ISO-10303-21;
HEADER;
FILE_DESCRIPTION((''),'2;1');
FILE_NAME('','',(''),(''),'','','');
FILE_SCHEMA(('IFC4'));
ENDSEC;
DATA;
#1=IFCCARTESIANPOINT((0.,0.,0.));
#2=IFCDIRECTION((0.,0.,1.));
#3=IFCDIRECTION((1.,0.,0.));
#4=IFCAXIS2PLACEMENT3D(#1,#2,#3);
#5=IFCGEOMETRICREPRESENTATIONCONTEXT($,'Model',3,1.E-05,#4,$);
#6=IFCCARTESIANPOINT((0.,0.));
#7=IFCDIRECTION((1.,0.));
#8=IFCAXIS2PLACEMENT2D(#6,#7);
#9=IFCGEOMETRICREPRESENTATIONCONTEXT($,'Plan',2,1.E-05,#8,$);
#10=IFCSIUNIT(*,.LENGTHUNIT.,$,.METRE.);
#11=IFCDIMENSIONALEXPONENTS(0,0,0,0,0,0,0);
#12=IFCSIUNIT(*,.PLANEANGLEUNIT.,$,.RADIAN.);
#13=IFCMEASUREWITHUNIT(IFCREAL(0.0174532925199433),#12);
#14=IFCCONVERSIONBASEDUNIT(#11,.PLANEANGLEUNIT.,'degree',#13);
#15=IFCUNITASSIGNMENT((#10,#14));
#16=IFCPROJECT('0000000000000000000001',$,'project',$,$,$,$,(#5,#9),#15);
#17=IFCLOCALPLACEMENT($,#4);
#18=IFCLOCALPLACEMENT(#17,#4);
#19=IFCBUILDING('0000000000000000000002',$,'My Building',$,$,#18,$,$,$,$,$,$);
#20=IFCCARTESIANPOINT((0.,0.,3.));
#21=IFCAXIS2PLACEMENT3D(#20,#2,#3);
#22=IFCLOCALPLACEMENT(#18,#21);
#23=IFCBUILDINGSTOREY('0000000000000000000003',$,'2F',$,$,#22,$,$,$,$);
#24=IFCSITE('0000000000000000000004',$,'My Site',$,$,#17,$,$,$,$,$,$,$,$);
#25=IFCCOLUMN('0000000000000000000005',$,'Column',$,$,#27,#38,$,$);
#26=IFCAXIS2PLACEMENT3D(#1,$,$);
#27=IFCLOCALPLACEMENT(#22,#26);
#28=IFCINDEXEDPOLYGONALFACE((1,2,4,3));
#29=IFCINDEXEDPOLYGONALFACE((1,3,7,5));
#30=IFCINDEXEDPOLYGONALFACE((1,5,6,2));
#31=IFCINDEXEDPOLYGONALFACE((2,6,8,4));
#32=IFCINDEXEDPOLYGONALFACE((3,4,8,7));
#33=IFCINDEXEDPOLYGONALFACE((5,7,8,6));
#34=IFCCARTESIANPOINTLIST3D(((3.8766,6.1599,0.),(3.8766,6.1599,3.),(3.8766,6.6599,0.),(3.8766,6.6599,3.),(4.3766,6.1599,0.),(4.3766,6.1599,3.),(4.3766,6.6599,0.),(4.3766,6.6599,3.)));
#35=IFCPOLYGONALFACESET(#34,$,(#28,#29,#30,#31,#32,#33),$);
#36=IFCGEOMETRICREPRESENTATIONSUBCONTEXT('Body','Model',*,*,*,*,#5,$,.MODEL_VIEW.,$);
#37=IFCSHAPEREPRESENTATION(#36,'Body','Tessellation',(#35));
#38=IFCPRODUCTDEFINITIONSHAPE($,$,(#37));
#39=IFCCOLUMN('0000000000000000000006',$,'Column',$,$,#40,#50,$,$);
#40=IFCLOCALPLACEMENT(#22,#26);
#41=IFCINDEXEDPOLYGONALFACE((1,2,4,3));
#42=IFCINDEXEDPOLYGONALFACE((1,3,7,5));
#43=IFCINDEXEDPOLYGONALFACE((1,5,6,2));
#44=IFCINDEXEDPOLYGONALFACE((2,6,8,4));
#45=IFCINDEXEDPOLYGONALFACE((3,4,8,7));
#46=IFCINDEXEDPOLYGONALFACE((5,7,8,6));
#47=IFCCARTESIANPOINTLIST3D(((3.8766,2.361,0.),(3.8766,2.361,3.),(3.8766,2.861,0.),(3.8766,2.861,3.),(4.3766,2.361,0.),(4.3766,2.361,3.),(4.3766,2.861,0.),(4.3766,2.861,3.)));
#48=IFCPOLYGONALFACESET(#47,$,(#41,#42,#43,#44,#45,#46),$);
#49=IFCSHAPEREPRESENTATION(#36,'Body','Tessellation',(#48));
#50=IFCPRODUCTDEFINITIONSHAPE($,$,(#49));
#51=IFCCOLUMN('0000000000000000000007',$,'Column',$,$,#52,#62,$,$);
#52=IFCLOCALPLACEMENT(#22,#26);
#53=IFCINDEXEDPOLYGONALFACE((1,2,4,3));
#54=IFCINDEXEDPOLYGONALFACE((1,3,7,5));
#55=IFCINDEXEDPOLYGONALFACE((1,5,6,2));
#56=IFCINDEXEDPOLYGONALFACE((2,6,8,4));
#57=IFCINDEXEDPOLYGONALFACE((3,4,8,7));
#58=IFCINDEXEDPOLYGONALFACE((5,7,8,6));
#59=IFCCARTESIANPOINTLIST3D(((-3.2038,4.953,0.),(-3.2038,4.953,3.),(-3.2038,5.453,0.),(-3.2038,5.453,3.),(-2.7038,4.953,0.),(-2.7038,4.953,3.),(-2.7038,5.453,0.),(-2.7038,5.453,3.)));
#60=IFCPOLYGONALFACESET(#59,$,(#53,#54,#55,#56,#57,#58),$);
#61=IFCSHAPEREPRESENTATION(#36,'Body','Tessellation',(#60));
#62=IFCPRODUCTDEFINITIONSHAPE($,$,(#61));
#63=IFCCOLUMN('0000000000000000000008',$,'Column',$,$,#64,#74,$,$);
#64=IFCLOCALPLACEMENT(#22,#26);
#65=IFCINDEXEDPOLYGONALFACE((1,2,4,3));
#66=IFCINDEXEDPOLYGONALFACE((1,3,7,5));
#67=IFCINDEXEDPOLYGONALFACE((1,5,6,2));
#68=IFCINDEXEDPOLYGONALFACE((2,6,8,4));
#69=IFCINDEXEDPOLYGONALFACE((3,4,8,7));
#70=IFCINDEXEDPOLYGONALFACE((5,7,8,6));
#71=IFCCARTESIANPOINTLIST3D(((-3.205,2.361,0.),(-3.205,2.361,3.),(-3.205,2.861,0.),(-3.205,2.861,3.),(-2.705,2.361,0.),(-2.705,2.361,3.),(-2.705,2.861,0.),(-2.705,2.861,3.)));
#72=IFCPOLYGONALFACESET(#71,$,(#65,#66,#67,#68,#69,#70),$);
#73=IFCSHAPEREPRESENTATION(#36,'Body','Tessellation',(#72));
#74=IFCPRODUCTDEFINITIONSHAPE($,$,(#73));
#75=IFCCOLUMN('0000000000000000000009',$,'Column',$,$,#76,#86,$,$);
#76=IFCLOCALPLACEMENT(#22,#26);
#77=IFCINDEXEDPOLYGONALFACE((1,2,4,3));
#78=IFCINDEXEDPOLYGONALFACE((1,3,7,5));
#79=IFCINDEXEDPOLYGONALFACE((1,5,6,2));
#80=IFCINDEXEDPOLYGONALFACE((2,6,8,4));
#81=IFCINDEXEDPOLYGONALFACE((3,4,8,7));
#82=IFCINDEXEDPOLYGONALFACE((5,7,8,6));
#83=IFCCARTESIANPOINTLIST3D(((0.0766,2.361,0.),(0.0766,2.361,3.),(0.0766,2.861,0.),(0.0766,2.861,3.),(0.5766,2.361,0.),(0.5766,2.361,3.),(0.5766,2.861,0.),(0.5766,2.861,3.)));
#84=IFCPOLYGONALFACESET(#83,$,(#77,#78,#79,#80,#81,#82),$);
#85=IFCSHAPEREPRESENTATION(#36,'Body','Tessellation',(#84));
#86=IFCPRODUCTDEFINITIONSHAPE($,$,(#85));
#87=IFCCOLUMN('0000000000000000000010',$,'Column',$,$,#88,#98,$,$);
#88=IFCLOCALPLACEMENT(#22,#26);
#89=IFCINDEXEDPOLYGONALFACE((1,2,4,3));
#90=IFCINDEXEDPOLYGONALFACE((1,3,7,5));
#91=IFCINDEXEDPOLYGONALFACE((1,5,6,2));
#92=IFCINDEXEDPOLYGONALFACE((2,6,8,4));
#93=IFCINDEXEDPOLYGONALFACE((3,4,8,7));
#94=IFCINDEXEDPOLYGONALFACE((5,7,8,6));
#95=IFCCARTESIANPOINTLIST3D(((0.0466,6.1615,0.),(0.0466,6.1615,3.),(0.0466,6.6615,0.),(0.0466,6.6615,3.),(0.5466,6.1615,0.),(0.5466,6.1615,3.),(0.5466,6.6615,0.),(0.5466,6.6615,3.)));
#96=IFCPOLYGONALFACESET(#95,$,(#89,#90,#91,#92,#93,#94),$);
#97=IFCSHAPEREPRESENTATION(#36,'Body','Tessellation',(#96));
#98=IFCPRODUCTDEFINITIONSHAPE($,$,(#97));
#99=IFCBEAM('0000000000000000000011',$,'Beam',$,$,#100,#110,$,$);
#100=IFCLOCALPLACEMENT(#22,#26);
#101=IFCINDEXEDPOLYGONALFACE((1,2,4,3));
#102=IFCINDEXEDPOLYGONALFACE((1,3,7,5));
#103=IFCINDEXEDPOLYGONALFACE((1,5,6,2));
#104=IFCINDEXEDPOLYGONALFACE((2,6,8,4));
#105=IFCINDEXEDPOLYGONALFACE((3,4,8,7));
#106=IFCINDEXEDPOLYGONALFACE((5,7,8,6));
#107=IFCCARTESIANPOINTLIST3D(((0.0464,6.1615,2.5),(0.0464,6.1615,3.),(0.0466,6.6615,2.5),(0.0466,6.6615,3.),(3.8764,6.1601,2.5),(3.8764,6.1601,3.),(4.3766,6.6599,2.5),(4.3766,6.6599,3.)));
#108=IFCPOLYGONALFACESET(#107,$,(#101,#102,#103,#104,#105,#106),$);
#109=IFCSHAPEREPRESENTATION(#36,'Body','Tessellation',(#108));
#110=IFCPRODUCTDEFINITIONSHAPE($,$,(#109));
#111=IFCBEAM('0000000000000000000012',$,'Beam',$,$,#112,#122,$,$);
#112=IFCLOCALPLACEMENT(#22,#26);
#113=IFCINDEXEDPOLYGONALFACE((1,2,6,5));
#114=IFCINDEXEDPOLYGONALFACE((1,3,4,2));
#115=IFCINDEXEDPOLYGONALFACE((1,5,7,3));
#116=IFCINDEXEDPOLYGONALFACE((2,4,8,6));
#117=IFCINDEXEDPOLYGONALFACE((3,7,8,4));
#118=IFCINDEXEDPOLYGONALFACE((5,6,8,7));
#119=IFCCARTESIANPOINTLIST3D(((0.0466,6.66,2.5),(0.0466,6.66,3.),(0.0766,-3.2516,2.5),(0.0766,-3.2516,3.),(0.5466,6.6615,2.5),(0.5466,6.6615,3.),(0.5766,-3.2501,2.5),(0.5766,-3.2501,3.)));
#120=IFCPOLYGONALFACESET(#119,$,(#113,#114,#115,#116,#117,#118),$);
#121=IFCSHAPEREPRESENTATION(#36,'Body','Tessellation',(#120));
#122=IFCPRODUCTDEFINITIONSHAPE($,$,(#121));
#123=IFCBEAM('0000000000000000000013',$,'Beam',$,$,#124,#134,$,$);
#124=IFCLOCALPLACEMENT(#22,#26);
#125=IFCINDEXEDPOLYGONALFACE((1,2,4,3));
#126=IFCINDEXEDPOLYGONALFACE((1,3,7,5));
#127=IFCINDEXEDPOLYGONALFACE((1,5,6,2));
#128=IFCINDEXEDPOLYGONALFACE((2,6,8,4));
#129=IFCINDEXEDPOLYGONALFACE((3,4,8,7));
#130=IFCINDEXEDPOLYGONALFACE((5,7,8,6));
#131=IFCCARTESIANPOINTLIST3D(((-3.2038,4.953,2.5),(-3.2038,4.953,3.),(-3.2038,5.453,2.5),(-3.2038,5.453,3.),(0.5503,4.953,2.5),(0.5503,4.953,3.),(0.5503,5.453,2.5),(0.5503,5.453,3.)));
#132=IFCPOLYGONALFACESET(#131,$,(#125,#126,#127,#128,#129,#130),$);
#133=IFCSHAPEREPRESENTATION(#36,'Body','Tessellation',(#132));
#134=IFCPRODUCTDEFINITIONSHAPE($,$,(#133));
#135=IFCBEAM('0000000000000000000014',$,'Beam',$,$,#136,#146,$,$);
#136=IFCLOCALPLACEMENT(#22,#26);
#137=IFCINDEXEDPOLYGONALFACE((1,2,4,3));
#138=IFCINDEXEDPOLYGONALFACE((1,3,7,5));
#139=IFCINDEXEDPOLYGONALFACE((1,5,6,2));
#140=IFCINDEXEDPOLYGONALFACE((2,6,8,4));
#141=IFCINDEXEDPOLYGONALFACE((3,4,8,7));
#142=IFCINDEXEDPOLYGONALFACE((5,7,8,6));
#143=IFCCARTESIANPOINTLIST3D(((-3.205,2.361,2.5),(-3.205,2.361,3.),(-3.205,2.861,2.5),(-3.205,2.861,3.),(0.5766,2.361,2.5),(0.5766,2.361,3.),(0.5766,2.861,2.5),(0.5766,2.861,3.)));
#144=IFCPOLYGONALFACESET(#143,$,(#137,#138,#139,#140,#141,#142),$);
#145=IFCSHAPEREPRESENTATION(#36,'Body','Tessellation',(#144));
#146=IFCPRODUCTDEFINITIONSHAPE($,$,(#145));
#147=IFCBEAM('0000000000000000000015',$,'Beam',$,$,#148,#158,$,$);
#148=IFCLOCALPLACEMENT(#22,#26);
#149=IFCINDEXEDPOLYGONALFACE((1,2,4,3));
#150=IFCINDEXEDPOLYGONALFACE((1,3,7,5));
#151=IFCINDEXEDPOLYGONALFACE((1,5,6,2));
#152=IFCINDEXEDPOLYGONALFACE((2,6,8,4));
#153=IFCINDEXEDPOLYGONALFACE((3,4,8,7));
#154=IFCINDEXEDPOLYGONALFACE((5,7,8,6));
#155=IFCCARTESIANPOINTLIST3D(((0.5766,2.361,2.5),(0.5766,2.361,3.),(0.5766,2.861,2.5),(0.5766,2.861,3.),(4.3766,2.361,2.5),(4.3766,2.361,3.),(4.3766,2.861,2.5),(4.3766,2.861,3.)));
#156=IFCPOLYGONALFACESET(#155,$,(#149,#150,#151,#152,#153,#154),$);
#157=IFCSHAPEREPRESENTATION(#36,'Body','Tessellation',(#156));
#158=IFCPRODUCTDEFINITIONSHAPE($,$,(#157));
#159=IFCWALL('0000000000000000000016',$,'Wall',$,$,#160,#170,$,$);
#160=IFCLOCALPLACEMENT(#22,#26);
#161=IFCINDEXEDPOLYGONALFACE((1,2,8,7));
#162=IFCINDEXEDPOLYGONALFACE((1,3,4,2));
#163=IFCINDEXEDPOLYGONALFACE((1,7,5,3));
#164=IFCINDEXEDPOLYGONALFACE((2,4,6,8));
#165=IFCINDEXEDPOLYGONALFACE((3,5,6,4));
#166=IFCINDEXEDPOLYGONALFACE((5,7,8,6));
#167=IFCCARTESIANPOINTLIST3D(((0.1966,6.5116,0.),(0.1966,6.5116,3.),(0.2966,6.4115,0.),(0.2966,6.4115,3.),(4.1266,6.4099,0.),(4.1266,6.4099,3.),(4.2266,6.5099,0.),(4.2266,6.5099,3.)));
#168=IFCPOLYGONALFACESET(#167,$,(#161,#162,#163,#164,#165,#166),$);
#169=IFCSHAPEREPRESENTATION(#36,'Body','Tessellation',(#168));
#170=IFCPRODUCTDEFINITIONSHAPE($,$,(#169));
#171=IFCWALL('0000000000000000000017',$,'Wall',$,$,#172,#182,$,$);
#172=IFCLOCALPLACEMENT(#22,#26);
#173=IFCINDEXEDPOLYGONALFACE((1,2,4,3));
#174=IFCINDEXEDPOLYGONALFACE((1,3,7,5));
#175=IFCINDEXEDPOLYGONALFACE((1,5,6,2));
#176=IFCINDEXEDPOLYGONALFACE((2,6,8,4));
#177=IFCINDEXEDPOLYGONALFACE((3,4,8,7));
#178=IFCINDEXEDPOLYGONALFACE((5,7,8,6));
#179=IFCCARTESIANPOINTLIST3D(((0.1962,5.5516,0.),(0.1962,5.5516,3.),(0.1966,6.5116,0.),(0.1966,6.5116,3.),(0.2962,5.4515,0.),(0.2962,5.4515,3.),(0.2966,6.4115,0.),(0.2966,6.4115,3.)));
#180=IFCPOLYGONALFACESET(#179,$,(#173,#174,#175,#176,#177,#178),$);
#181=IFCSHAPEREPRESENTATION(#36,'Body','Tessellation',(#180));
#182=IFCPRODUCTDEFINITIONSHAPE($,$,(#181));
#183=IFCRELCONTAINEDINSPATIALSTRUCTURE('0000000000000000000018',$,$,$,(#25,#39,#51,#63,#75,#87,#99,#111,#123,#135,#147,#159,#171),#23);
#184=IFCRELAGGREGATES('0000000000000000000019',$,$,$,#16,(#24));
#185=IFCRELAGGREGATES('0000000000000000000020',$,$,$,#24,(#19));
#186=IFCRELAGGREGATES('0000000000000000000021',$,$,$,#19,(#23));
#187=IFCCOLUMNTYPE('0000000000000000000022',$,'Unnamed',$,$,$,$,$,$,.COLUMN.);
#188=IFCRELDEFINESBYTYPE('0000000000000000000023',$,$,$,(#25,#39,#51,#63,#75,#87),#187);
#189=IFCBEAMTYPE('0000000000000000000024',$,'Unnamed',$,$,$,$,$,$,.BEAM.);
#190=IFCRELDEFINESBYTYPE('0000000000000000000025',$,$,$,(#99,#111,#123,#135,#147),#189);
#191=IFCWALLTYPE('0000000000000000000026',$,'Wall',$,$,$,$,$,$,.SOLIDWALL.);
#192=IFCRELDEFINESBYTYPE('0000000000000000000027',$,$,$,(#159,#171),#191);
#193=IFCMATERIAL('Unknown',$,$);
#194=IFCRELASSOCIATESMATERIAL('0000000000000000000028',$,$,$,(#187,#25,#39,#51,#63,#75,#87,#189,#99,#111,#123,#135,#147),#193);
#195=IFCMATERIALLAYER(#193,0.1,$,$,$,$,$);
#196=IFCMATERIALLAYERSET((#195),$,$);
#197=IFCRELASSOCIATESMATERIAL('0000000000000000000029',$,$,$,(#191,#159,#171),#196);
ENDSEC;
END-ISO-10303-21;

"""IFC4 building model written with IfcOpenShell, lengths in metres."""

from ifc_helpers import new_model, entity, si_unit, converted_unit, frame, origin_with_axes, origin_2d_with_axis, place, context, subcontext, project, spatial, line, indexed_curve, rectangle, outline, extrude, clip, halfspace, material, layer, layer_set, layer_usage, material_profile, profile_set, profile_usage, type_object, element, save


model = new_model("IFC4")

# Units and contexts
model_context = context("Model", 3, precision=1e-05, world=origin_with_axes())
plan_context = context("Plan", 2, precision=1e-05, world=origin_2d_with_axis())
body_context_1 = subcontext(model_context, "Body", "Model", "MODEL_VIEW")
ifc_project = project(units=[si_unit("LENGTHUNIT", "METRE"), converted_unit("PLANEANGLEUNIT", "degree", entity("IfcReal", 0.0174532925199433), si_unit("PLANEANGLEUNIT", "RADIAN"), dimensions=[0, 0, 0, 0, 0, 0, 0])], contexts=[model_context, plan_context])

# Site, building, storey
site_placement = place(None, origin_with_axes())
site = spatial("IfcSite", under=ifc_project, at=site_placement, Name="My Site")
building_placement = place(site_placement, origin_with_axes())
building = spatial("IfcBuilding", under=site, at=building_placement, Name="My Building")
storey_placement = place(building_placement, frame((0.0, 0.0, 3.0), z_axis=(0.0, 0.0, 1.0), x_axis=(1.0, 0.0, 0.0)))
storey = spatial("IfcBuildingStorey", under=building, at=storey_placement, Name="2F")

# Columns
ifc_material = material(Name="Unknown")
ifc_material_profile_1 = material_profile(ifc_material, rectangle(XDim=0.5, YDim=0.5))
ifc_profile_set_1 = profile_set([ifc_material_profile_1])
ifc_profile_usage_1 = profile_usage(ifc_profile_set_1, cardinal=9)
column_type = type_object("IfcColumnType", Name="Unnamed", PredefinedType="COLUMN", material=ifc_profile_set_1)
column_1_placement = place(storey_placement, frame((3.8766, 6.6599, 0.0), z_axis=(0.0, 0.0, 1.0), x_axis=(1.0, 0.0, 0.0)))
element("IfcColumn", 1, at=column_1_placement, inside=storey, type_object=column_type, material=ifc_profile_usage_1, Name="Column", context=body_context_1, shape_type="SweptSolid", body=[
    extrude(rectangle(XDim=0.5, YDim=0.5), frame((0.25, -0.25, 0.0), z_axis=(0.0, 0.0, 1.0), x_axis=(1.0, 0.0, 0.0)), (0.0, 0.0, 1.0), 3.0),
])
ifc_profile_usage_2 = profile_usage(ifc_profile_set_1, cardinal=7)
column_2_placement = place(storey_placement, frame((4.3766, 2.861, 0.0), z_axis=(0.0, 0.0, 1.0), x_axis=(1.0, 0.0, 0.0)))
element("IfcColumn", 2, at=column_2_placement, inside=storey, type_object=column_type, material=ifc_profile_usage_2, Name="Column", context=body_context_1, shape_type="SweptSolid", body=[
    extrude(rectangle(XDim=0.5, YDim=0.5), frame((-0.25, -0.25, 0.0), z_axis=(0.0, 0.0, 1.0), x_axis=(1.0, 0.0, 0.0)), (0.0, 0.0, 1.0), 3.0),
])
ifc_profile_usage_3 = profile_usage(ifc_profile_set_1, cardinal=9)
column_3_placement = place(storey_placement, frame((-3.2038, 5.453, 0.0), z_axis=(0.0, 0.0, 1.0), x_axis=(1.0, 0.0, 0.0)))
element("IfcColumn", 3, at=column_3_placement, inside=storey, type_object=column_type, material=ifc_profile_usage_3, Name="Column", context=body_context_1, shape_type="SweptSolid", body=[
    extrude(rectangle(XDim=0.5, YDim=0.5), frame((0.25, -0.25, 0.0), z_axis=(0.0, 0.0, 1.0), x_axis=(1.0, 0.0, 0.0)), (0.0, 0.0, 1.0), 3.0),
])
ifc_profile_usage_4 = profile_usage(ifc_profile_set_1, cardinal=7)
column_4_placement = place(storey_placement, frame((-2.705, 2.861, 0.0), z_axis=(0.0, 0.0, 1.0), x_axis=(1.0, 0.0, 0.0)))
element("IfcColumn", 4, at=column_4_placement, inside=storey, type_object=column_type, material=ifc_profile_usage_4, Name="Column", context=body_context_1, shape_type="SweptSolid", body=[
    extrude(rectangle(XDim=0.5, YDim=0.5), frame((-0.25, -0.25, 0.0), z_axis=(0.0, 0.0, 1.0), x_axis=(1.0, 0.0, 0.0)), (0.0, 0.0, 1.0), 3.0),
])
ifc_profile_usage_5 = profile_usage(ifc_profile_set_1, cardinal=7)
column_5_placement = place(storey_placement, frame((0.5766, 2.861, 0.0), z_axis=(0.0, 0.0, 1.0), x_axis=(1.0, 0.0, 0.0)))
element("IfcColumn", 5, at=column_5_placement, inside=storey, type_object=column_type, material=ifc_profile_usage_5, Name="Column", context=body_context_1, shape_type="SweptSolid", body=[
    extrude(rectangle(XDim=0.5, YDim=0.5), frame((-0.25, -0.25, 0.0), z_axis=(0.0, 0.0, 1.0), x_axis=(1.0, 0.0, 0.0)), (0.0, 0.0, 1.0), 3.0),
])
ifc_profile_usage_6 = profile_usage(ifc_profile_set_1, cardinal=7)
column_6_placement = place(storey_placement, frame((0.5466, 6.6615, 0.0), z_axis=(0.0, 0.0, 1.0), x_axis=(1.0, 0.0, 0.0)))
element("IfcColumn", 6, at=column_6_placement, inside=storey, type_object=column_type, material=ifc_profile_usage_6, Name="Column", context=body_context_1, shape_type="SweptSolid", body=[
    extrude(rectangle(XDim=0.5, YDim=0.5), frame((-0.25, -0.25, 0.0), z_axis=(0.0, 0.0, 1.0), x_axis=(1.0, 0.0, 0.0)), (0.0, 0.0, 1.0), 3.0),
])

# Beams
ifc_material_profile_2 = material_profile(ifc_material, rectangle(XDim=0.5, YDim=0.5))
ifc_profile_set_2 = profile_set([ifc_material_profile_2])
ifc_profile_usage_7 = profile_usage(ifc_profile_set_2, cardinal=7)
beam_type = type_object("IfcBeamType", Name="Unnamed", PredefinedType="BEAM", material=ifc_profile_set_2)
beam_1_placement = place(storey_placement, frame((0.0466, 6.6615, 3.0), z_axis=(1.0, -0.000377, 0.0), x_axis=(0.000377, 1.0, 0.0)))
element("IfcBeam", 7, at=beam_1_placement, inside=storey, type_object=beam_type, material=ifc_profile_usage_7, Name="Beam", context=body_context_1, shape_type="Clipping", body=[
    clip(extrude(rectangle(XDim=0.5, YDim=0.5), frame((-0.25, -0.25, 0.0), z_axis=(0.0, 0.0, 1.0), x_axis=(1.0, 0.0, 0.0)), (0.0, 0.0, 1.0), 4.83), halfspace(frame((0.0, -6.0, 4.33), z_axis=(-0.707114, 0.0, 0.707099), x_axis=(0.0, 1.0, 0.0)), False)),
])
ifc_profile_usage_8 = profile_usage(ifc_profile_set_2, cardinal=7)
beam_2_placement = place(storey_placement, frame((0.5466, 6.6615, 3.0), z_axis=(0.003031, -0.999995, 0.0), x_axis=(0.999995, 0.003031, 0.0)))
element("IfcBeam", 8, at=beam_2_placement, inside=storey, type_object=beam_type, material=ifc_profile_usage_8, Name="Beam", context=body_context_1, shape_type="SweptSolid", body=[
    extrude(rectangle(XDim=0.5, YDim=0.5), frame((-0.25, -0.25, 0.0), z_axis=(0.0, 0.0, 1.0), x_axis=(1.0, 0.0, 0.0)), (0.0, 0.0, 1.0), 9.9117),
])
ifc_profile_usage_9 = profile_usage(ifc_profile_set_2, cardinal=7)
beam_3_placement = place(storey_placement, frame((-3.2038, 5.453, 3.0), z_axis=(1.0, 0.0, 0.000001), x_axis=(0.0, 1.0, 0.0)))
element("IfcBeam", 9, at=beam_3_placement, inside=storey, type_object=beam_type, material=ifc_profile_usage_9, Name="Beam", context=body_context_1, shape_type="SweptSolid", body=[
    extrude(rectangle(XDim=0.5, YDim=0.5), frame((-0.25, -0.25, 0.0), z_axis=(0.0, 0.0, 1.0), x_axis=(1.0, 0.0, 0.0)), (0.0, 0.0, 1.0), 3.7541),
])
ifc_profile_usage_10 = profile_usage(ifc_profile_set_2, cardinal=7)
beam_4_placement = place(storey_placement, frame((-3.205, 2.861, 3.0), z_axis=(1.0, 0.0, 0.0), x_axis=(0.0, 1.0, 0.0)))
element("IfcBeam", 10, at=beam_4_placement, inside=storey, type_object=beam_type, material=ifc_profile_usage_10, Name="Beam", context=body_context_1, shape_type="SweptSolid", body=[
    extrude(rectangle(XDim=0.5, YDim=0.5), frame((-0.25, -0.25, 0.0), z_axis=(0.0, 0.0, 1.0), x_axis=(1.0, 0.0, 0.0)), (0.0, 0.0, 1.0), 3.7816),
])
ifc_profile_usage_11 = profile_usage(ifc_profile_set_2, cardinal=7)
beam_5_placement = place(storey_placement, frame((0.5766, 2.861, 3.0), z_axis=(1.0, 0.000001, 0.0), x_axis=(-0.000001, 1.0, 0.0)))
element("IfcBeam", 11, at=beam_5_placement, inside=storey, type_object=beam_type, material=ifc_profile_usage_11, Name="Beam", context=body_context_1, shape_type="SweptSolid", body=[
    extrude(rectangle(XDim=0.5, YDim=0.5), frame((-0.25, -0.25, 0.0), z_axis=(0.0, 0.0, 1.0), x_axis=(1.0, 0.0, 0.0)), (0.0, 0.0, 1.0), 3.8),
])

# Walls
ifc_layer = layer(ifc_material, 0.1)
ifc_layer_set = layer_set([ifc_layer])
ifc_layer_usage_1 = layer_usage(ifc_layer_set, "AXIS2", "POSITIVE", 0.0)
wall_type = type_object("IfcWallType", Name="Wall", PredefinedType="SOLIDWALL", material=ifc_layer_set)
wall_1_placement = place(storey_placement, frame((4.2266, 6.5099, 0.0), z_axis=(0.0, 0.0, 1.0), x_axis=(-1.0, 0.000415, 0.0)))
element("IfcWall", 12, at=wall_1_placement, inside=storey, type_object=wall_type, material=ifc_layer_usage_1, Name="Wall", context=body_context_1, shape_type="SweptSolid", body=[
    extrude(outline(indexed_curve([(0.0, 0.0), (0.1, 0.1), (3.93, 0.1), (4.03, 0.0)], segments=[line(1, 2, 3, 4, 1)])), origin_with_axes(), (0.0, 0.0, 1.0), 3.0),
])
ifc_layer_usage_2 = layer_usage(ifc_layer_set, "AXIS2", "POSITIVE", 0.0)
wall_2_placement = place(storey_placement, frame((0.1966, 6.5116, 0.0), z_axis=(0.0, 0.0, 1.0), x_axis=(-0.000415, -1.0, 0.0)))
element("IfcWall", 13, at=wall_2_placement, inside=storey, type_object=wall_type, material=ifc_layer_usage_2, Name="Wall", context=body_context_1, shape_type="SweptSolid", body=[
    extrude(outline(indexed_curve([(0.0, 0.0), (0.1, 0.1), (1.06, 0.1), (0.96, 0.0)], segments=[line(1, 2, 3, 4, 1)])), origin_with_axes(), (0.0, 0.0, 1.0), 3.0),
])

save(model, "model.ifc")
